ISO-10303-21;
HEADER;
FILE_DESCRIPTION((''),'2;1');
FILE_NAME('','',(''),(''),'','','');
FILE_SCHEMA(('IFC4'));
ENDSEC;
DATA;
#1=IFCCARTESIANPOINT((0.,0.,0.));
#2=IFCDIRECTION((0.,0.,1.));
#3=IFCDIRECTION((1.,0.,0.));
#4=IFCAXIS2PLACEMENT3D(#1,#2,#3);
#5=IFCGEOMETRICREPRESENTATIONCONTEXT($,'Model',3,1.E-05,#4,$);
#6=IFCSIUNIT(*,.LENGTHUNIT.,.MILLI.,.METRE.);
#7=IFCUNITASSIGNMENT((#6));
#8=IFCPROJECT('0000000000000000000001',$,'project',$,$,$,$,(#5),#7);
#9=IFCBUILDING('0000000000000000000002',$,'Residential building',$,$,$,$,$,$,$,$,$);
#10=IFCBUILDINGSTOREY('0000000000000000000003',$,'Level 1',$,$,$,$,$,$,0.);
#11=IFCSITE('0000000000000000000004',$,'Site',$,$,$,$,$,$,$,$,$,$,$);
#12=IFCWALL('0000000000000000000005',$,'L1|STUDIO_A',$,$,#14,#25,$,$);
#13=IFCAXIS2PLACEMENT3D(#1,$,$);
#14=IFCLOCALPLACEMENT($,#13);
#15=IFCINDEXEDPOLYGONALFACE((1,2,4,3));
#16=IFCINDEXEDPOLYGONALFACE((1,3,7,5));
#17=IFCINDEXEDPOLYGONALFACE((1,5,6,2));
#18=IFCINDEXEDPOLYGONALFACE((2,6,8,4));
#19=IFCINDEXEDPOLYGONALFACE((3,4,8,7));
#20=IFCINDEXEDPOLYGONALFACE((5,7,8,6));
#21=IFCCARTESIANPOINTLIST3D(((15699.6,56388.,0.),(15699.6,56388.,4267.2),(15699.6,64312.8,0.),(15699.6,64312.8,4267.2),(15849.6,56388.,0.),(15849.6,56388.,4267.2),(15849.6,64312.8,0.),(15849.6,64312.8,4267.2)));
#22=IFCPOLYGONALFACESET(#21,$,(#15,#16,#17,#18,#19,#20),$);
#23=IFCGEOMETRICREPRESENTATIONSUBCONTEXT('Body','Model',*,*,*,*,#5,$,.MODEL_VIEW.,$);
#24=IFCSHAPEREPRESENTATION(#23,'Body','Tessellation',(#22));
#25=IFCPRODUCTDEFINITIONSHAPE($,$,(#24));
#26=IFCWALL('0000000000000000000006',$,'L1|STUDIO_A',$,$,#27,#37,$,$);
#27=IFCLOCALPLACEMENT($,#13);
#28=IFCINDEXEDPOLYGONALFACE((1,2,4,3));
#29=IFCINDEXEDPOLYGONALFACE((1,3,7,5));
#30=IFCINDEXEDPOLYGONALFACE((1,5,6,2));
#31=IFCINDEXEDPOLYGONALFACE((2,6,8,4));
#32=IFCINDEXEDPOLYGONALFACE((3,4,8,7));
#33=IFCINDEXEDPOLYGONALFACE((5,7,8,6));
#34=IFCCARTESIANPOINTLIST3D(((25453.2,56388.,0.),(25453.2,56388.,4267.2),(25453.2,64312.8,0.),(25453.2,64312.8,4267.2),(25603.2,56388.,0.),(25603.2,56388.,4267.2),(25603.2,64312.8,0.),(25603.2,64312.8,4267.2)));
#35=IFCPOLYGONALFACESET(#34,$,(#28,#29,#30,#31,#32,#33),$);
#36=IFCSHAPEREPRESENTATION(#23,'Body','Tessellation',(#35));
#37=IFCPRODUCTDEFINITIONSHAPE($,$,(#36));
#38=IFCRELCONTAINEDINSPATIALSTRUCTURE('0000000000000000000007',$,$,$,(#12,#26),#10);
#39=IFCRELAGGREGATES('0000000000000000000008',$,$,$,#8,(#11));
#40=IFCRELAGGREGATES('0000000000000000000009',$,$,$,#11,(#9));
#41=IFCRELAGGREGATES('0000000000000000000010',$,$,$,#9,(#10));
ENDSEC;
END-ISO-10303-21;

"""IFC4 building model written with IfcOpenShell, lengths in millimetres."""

from ifc_helpers import new_model, si_unit, frame, origin_with_axes, place, context, subcontext, project, spatial, indexed_curve, outline, extrude, element, save


model = new_model("IFC4")

# Units and contexts
model_context = context("Model", 3, precision=1e-05, world=origin_with_axes())
body_context = subcontext(model_context, "Body", "Model", "MODEL_VIEW")
ifc_project = project(units=[si_unit("LENGTHUNIT", "METRE", prefix="MILLI")], contexts=[model_context])

# Site, building, storey
site = spatial("IfcSite", under=ifc_project, Name="Site")
building = spatial("IfcBuilding", under=site, Name="Residential building")
storey = spatial("IfcBuildingStorey", under=building, Name="Level 1", Elevation=0.0)

# Walls
for number, where, z_axis, x_axis, name in (
    (1, (15849.6, 56388.0, 0.0), (0.0, 0.0, 1.0), (0.0, 1.0, 0.0), "L1|STUDIO_A"),
    (2, (25603.2, 56388.0, 0.0), (0.0, 0.0, 1.0), (0.0, 1.0, 0.0), "L1|STUDIO_A"),
):
    element("IfcWall", number, at=place(None, frame(where, z_axis=z_axis, x_axis=x_axis)), inside=storey, Name=name, context=body_context, shape_type="SweptSolid", body=[
        extrude(outline(indexed_curve([(0.0, 0.0), (0.0, 150.0), (7924.8, 150.0), (7924.8, 0.0), (0.0, 0.0)], self_intersect=False)), origin_with_axes(), (0.0, 0.0, 1.0), 4267.2),
    ])

save(model, "model.ifc")
